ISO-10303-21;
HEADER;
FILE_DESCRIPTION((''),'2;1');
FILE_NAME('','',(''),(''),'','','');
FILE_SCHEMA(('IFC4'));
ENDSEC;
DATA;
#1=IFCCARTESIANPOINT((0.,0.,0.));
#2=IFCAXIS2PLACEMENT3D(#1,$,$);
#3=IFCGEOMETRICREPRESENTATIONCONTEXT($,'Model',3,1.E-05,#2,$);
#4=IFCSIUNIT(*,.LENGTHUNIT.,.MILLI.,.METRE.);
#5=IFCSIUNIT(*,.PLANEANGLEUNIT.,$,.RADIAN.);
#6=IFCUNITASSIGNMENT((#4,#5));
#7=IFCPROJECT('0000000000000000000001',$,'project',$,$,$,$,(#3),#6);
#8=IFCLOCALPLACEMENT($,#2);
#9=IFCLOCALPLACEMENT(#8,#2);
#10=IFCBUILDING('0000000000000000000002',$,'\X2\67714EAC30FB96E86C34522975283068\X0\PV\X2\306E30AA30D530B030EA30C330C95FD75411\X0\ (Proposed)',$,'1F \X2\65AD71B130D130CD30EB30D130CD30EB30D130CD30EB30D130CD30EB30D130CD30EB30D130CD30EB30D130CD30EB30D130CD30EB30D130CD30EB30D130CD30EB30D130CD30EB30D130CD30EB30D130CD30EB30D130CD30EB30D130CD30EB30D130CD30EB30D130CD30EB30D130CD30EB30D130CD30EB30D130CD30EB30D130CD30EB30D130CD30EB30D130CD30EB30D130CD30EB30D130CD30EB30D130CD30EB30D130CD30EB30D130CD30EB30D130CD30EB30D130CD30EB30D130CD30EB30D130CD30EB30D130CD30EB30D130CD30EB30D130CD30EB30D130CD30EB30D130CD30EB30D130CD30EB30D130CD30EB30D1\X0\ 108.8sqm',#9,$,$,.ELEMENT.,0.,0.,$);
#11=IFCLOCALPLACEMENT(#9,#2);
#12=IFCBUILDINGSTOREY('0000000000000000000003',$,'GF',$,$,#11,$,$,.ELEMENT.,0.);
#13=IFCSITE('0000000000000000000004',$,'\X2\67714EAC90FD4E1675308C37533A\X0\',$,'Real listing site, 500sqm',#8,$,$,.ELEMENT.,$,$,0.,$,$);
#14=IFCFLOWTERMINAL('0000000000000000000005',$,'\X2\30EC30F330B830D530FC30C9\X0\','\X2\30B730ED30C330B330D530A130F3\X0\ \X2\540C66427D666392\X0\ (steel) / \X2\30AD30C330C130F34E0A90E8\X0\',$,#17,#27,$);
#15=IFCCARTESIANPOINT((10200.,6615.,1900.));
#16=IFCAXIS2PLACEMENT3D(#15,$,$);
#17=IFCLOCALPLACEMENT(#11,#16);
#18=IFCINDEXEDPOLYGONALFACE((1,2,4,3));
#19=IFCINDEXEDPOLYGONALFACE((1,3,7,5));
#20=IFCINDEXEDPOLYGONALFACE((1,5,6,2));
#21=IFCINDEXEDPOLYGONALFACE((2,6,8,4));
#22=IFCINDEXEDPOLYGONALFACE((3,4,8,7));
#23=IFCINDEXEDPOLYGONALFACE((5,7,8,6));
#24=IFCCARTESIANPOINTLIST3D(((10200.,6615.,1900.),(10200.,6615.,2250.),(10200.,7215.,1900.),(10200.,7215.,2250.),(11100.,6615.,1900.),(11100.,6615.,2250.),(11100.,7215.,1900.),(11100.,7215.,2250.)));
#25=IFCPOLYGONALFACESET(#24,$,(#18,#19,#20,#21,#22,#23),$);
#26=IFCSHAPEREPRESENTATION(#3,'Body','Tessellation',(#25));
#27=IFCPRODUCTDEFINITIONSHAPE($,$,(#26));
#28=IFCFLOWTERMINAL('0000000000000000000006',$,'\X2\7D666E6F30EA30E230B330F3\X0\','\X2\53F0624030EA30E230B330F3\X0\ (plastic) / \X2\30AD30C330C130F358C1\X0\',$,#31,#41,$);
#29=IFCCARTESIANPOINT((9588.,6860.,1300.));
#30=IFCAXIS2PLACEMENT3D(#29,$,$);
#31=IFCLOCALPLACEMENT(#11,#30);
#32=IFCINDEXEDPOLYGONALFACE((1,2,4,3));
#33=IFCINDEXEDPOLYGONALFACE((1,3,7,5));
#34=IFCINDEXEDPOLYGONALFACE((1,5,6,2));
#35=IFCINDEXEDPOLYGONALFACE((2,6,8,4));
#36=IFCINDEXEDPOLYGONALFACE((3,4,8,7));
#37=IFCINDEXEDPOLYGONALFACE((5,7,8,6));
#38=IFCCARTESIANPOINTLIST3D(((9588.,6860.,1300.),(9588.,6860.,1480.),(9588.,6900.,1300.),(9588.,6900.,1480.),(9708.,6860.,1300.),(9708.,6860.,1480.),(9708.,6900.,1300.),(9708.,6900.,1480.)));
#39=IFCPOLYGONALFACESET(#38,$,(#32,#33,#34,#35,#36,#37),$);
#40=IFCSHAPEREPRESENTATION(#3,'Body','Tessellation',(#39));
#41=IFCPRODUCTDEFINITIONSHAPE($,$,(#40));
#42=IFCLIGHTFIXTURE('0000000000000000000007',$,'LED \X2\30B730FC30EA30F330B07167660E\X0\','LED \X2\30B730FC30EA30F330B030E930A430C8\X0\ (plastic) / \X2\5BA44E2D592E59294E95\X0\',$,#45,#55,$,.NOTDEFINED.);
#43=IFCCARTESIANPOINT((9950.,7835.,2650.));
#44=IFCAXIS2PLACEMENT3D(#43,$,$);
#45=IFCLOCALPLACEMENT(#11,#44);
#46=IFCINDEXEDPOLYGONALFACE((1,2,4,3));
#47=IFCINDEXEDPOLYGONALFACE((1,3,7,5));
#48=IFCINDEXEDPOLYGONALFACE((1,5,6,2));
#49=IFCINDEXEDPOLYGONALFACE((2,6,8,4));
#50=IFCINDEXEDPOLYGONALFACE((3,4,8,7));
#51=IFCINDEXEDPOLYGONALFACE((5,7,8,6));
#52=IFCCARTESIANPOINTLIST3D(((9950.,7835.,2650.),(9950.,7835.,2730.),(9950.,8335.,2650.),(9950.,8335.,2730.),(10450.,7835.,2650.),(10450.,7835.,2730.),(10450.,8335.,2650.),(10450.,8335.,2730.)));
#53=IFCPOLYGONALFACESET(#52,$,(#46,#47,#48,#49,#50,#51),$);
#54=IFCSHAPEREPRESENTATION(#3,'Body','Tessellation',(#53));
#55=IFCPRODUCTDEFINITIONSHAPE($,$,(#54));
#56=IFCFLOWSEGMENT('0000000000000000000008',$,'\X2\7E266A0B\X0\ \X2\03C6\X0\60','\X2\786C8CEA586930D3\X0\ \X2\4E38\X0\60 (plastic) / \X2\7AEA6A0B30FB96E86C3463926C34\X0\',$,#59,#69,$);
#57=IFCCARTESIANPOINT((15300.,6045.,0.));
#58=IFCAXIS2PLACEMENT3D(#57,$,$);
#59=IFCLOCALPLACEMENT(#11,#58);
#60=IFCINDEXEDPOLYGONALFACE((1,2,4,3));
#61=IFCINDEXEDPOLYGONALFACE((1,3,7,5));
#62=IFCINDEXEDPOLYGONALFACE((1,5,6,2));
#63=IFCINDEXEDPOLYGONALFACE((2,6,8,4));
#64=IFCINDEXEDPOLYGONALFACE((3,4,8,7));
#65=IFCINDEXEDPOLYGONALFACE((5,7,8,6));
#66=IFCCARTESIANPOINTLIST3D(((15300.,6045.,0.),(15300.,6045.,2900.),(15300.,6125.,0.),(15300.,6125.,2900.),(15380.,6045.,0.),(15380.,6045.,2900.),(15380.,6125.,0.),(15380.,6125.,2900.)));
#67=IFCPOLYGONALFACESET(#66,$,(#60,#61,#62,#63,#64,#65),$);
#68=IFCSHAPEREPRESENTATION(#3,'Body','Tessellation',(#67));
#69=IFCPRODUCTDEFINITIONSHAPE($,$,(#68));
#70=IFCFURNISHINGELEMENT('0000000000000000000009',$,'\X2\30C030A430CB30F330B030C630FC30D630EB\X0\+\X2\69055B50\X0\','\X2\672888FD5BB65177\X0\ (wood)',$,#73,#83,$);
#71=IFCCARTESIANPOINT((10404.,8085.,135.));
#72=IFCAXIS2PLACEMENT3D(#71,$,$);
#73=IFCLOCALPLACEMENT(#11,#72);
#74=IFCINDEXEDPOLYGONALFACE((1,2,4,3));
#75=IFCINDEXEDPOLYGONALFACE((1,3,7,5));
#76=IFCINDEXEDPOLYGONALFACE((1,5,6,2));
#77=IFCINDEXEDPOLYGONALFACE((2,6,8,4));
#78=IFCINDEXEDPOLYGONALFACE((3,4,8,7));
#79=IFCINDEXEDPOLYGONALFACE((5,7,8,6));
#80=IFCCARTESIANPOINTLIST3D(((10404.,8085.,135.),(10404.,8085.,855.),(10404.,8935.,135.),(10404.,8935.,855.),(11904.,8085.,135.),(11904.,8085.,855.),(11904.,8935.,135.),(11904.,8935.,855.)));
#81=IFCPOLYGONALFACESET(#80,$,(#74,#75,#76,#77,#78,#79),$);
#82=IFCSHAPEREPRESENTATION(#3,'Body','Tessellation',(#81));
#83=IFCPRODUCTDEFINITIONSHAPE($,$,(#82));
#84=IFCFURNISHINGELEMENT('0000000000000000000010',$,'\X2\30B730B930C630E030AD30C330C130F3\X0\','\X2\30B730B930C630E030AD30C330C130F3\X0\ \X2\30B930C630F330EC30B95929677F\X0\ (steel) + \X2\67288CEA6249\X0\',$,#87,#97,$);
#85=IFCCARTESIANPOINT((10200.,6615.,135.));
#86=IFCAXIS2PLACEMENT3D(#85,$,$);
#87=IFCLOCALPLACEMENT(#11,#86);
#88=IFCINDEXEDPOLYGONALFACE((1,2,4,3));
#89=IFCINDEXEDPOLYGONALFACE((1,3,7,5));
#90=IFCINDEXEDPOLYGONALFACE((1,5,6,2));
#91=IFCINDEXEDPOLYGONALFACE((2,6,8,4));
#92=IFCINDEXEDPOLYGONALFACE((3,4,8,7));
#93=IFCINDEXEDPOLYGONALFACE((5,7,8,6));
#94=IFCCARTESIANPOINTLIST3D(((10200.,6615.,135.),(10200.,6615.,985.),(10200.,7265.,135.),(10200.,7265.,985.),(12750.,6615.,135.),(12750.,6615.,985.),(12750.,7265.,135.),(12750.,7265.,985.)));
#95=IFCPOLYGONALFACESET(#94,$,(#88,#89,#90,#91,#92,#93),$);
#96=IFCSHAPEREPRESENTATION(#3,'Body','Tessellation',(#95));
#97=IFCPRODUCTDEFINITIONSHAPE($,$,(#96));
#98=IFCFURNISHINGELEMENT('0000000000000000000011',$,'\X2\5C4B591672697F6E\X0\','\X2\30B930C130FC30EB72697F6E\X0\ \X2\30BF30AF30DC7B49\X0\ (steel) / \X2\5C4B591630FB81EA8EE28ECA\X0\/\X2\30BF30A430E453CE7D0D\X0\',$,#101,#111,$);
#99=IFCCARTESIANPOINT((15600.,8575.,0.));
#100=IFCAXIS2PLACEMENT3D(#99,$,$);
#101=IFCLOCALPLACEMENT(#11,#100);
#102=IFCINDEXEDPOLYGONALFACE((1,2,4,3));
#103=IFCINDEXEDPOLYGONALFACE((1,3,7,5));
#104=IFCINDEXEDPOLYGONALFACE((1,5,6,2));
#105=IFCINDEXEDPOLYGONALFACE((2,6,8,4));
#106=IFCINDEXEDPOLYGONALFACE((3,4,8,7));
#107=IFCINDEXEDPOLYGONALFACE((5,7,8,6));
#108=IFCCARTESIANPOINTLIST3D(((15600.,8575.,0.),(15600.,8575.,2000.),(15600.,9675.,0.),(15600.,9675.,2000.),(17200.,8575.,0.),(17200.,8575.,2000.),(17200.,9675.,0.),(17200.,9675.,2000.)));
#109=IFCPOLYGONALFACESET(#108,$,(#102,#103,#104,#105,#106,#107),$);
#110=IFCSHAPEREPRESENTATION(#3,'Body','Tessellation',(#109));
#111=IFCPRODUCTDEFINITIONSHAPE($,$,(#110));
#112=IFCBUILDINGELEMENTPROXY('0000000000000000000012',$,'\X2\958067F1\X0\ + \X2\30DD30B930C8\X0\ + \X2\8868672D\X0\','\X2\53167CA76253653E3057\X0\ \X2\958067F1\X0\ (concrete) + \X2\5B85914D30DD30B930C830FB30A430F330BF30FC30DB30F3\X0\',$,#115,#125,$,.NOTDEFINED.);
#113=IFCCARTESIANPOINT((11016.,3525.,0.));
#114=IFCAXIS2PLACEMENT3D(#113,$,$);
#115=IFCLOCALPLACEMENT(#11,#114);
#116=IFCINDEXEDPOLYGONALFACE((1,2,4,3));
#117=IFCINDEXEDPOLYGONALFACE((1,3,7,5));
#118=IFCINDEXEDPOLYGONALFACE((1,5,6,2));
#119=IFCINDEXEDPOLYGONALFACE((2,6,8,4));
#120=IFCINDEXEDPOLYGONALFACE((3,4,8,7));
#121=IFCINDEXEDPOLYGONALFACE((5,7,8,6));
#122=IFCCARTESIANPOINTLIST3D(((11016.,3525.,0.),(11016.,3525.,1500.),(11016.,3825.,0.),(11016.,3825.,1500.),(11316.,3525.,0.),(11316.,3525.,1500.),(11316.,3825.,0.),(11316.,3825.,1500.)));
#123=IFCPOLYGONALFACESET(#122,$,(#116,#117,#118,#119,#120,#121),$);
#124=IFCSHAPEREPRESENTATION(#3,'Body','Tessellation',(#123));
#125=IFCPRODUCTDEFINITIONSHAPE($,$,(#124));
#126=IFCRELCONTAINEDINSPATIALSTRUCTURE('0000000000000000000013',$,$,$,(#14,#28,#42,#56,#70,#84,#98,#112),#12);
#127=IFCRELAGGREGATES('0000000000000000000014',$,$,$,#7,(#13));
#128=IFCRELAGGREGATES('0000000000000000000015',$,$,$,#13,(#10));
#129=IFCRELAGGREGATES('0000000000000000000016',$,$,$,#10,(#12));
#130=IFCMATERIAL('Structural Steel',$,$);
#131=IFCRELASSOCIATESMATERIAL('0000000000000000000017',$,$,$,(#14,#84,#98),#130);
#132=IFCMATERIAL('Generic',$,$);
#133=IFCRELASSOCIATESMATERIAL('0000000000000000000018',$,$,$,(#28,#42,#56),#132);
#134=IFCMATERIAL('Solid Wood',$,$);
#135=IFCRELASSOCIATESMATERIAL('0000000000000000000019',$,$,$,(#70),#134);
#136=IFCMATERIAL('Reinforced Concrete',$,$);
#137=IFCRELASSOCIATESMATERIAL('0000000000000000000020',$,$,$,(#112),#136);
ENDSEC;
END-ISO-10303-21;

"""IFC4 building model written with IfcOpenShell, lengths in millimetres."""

from ifc_helpers import new_model, si_unit, frame, frame_2d, origin, place, context, project, spatial, rectangle, extrude, material, element, save


model = new_model("IFC4")

# Units and contexts
model_context = context("Model", 3, precision=1e-05, world=origin())
ifc_project = project(units=[si_unit("LENGTHUNIT", "METRE", prefix="MILLI"), si_unit("PLANEANGLEUNIT", "RADIAN")], contexts=[model_context])

# Site, building, storey
site_placement = place(None, origin())
site = spatial("IfcSite", under=ifc_project, at=site_placement, Name="東京都世田谷区", ObjectType="Real listing site, 500sqm", CompositionType="ELEMENT", RefElevation=0.0)
building_placement = place(site_placement, origin())
building = spatial("IfcBuilding", under=site, at=building_placement, Name="東京・雨水利用とPVのオフグリッド志向 (Proposed)", ObjectType="1F 断熱パネルパネルパネルパネルパネルパネルパネルパネルパネルパネルパネルパネルパネルパネルパネルパネルパネルパネルパネルパネルパネルパネルパネルパネルパネルパネルパネルパネルパネルパネルパネルパネルパネルパネルパネルパネルパネルパネルパネルパ 108.8sqm", CompositionType="ELEMENT", ElevationOfRefHeight=0.0, ElevationOfTerrain=0.0)
storey_placement = place(building_placement, origin())
storey = spatial("IfcBuildingStorey", under=building, at=storey_placement, Name="GF", CompositionType="ELEMENT", Elevation=0.0)

# Shared definitions
ifc_material_1 = material(Name="Solid Wood")

# Shared definitions
ifc_material_2 = material(Name="Structural Steel")

# Shared definitions
ifc_material_3 = material(Name="Reinforced Concrete")

# Flow terminals
flow_terminal_1_placement = place(storey_placement, frame((10200.0, 6615.0, 1900.0)))
element("IfcFlowTerminal", 1, at=flow_terminal_1_placement, inside=storey, material=ifc_material_2, Name="レンジフード", Description="シロッコファン 同時給排 (steel) / キッチン上部", context=model_context, shape_type="SweptSolid", body=[
    extrude(rectangle(XDim=900.0, YDim=600.0, at=frame_2d((450.0, 300.0))), frame((10200.0, 6615.0, 1900.0)), (0.0, 0.0, 1.0), 350.0),
])
ifc_material_4 = material(Name="Generic")
flow_terminal_2_placement = place(storey_placement, frame((9588.0, 6860.0, 1300.0)))
element("IfcFlowTerminal", 2, at=flow_terminal_2_placement, inside=storey, material=ifc_material_4, Name="給湯リモコン", Description="台所リモコン (plastic) / キッチン壁", context=model_context, shape_type="SweptSolid", body=[
    extrude(rectangle(XDim=120.0, YDim=40.0, at=frame_2d((60.0, 20.0))), frame((9588.0, 6860.0, 1300.0)), (0.0, 0.0, 1.0), 180.0),
])

# Light fixture
light_fixture_placement = place(storey_placement, frame((9950.0, 7835.0, 2650.0)))
element("IfcLightFixture", 3, at=light_fixture_placement, inside=storey, material=ifc_material_4, Name="LED シーリング照明", Description="LED シーリングライト (plastic) / 室中央天井", PredefinedType="NOTDEFINED", context=model_context, shape_type="SweptSolid", body=[
    extrude(rectangle(XDim=500.0, YDim=500.0, at=frame_2d((250.0, 250.0))), frame((9950.0, 7835.0, 2650.0)), (0.0, 0.0, 1.0), 80.0),
])

# Flow segment
flow_segment_placement = place(storey_placement, frame((15300.0, 6045.0, 0.0)))
element("IfcFlowSegment", 4, at=flow_segment_placement, inside=storey, material=ifc_material_4, Name="縦樋 φ60", Description="硬質塩ビ 丸60 (plastic) / 竪樋・雨水排水", context=model_context, shape_type="SweptSolid", body=[
    extrude(rectangle(XDim=80.0, YDim=80.0, at=frame_2d((40.0, 40.0))), frame((15300.0, 6045.0, 0.0)), (0.0, 0.0, 1.0), 2900.0),
])

# Furnishing elements
furnishing_1_placement = place(storey_placement, frame((10404.0, 8085.0, 135.0)))
element("IfcFurnishingElement", 5, at=furnishing_1_placement, inside=storey, material=ifc_material_1, Name="ダイニングテーブル+椅子", Description="木製家具 (wood)", context=model_context, shape_type="SweptSolid", body=[
    extrude(rectangle(XDim=1500.0, YDim=850.0, at=frame_2d((750.0, 425.0))), frame((10404.0, 8085.0, 135.0)), (0.0, 0.0, 1.0), 720.0),
])
furnishing_2_placement = place(storey_placement, frame((10200.0, 6615.0, 135.0)))
element("IfcFurnishingElement", 6, at=furnishing_2_placement, inside=storey, material=ifc_material_2, Name="システムキッチン", Description="システムキッチン ステンレス天板 (steel) + 木質扉", context=model_context, shape_type="SweptSolid", body=[
    extrude(rectangle(XDim=2550.0, YDim=650.0, at=frame_2d((1275.0, 325.0))), frame((10200.0, 6615.0, 135.0)), (0.0, 0.0, 1.0), 850.0),
])
furnishing_3_placement = place(storey_placement, frame((15600.0, 8575.0, 0.0)))
element("IfcFurnishingElement", 7, at=furnishing_3_placement, inside=storey, material=ifc_material_2, Name="屋外物置", Description="スチール物置 タクボ等 (steel) / 屋外・自転車/タイヤ収納", context=model_context, shape_type="SweptSolid", body=[
    extrude(rectangle(XDim=1600.0, YDim=1100.0, at=frame_2d((800.0, 550.0))), frame((15600.0, 8575.0, 0.0)), (0.0, 0.0, 1.0), 2000.0),
])

# Building element proxy
proxy_placement = place(storey_placement, frame((11016.0, 3525.0, 0.0)))
element("IfcBuildingElementProxy", 8, at=proxy_placement, inside=storey, material=ifc_material_3, Name="門柱 + ポスト + 表札", Description="化粧打放し 門柱 (concrete) + 宅配ポスト・インターホン", PredefinedType="NOTDEFINED", context=model_context, shape_type="SweptSolid", body=[
    extrude(rectangle(XDim=300.0, YDim=300.0, at=frame_2d((150.0, 150.0))), frame((11016.0, 3525.0, 0.0)), (0.0, 0.0, 1.0), 1500.0),
])

save(model, "model.ifc")
